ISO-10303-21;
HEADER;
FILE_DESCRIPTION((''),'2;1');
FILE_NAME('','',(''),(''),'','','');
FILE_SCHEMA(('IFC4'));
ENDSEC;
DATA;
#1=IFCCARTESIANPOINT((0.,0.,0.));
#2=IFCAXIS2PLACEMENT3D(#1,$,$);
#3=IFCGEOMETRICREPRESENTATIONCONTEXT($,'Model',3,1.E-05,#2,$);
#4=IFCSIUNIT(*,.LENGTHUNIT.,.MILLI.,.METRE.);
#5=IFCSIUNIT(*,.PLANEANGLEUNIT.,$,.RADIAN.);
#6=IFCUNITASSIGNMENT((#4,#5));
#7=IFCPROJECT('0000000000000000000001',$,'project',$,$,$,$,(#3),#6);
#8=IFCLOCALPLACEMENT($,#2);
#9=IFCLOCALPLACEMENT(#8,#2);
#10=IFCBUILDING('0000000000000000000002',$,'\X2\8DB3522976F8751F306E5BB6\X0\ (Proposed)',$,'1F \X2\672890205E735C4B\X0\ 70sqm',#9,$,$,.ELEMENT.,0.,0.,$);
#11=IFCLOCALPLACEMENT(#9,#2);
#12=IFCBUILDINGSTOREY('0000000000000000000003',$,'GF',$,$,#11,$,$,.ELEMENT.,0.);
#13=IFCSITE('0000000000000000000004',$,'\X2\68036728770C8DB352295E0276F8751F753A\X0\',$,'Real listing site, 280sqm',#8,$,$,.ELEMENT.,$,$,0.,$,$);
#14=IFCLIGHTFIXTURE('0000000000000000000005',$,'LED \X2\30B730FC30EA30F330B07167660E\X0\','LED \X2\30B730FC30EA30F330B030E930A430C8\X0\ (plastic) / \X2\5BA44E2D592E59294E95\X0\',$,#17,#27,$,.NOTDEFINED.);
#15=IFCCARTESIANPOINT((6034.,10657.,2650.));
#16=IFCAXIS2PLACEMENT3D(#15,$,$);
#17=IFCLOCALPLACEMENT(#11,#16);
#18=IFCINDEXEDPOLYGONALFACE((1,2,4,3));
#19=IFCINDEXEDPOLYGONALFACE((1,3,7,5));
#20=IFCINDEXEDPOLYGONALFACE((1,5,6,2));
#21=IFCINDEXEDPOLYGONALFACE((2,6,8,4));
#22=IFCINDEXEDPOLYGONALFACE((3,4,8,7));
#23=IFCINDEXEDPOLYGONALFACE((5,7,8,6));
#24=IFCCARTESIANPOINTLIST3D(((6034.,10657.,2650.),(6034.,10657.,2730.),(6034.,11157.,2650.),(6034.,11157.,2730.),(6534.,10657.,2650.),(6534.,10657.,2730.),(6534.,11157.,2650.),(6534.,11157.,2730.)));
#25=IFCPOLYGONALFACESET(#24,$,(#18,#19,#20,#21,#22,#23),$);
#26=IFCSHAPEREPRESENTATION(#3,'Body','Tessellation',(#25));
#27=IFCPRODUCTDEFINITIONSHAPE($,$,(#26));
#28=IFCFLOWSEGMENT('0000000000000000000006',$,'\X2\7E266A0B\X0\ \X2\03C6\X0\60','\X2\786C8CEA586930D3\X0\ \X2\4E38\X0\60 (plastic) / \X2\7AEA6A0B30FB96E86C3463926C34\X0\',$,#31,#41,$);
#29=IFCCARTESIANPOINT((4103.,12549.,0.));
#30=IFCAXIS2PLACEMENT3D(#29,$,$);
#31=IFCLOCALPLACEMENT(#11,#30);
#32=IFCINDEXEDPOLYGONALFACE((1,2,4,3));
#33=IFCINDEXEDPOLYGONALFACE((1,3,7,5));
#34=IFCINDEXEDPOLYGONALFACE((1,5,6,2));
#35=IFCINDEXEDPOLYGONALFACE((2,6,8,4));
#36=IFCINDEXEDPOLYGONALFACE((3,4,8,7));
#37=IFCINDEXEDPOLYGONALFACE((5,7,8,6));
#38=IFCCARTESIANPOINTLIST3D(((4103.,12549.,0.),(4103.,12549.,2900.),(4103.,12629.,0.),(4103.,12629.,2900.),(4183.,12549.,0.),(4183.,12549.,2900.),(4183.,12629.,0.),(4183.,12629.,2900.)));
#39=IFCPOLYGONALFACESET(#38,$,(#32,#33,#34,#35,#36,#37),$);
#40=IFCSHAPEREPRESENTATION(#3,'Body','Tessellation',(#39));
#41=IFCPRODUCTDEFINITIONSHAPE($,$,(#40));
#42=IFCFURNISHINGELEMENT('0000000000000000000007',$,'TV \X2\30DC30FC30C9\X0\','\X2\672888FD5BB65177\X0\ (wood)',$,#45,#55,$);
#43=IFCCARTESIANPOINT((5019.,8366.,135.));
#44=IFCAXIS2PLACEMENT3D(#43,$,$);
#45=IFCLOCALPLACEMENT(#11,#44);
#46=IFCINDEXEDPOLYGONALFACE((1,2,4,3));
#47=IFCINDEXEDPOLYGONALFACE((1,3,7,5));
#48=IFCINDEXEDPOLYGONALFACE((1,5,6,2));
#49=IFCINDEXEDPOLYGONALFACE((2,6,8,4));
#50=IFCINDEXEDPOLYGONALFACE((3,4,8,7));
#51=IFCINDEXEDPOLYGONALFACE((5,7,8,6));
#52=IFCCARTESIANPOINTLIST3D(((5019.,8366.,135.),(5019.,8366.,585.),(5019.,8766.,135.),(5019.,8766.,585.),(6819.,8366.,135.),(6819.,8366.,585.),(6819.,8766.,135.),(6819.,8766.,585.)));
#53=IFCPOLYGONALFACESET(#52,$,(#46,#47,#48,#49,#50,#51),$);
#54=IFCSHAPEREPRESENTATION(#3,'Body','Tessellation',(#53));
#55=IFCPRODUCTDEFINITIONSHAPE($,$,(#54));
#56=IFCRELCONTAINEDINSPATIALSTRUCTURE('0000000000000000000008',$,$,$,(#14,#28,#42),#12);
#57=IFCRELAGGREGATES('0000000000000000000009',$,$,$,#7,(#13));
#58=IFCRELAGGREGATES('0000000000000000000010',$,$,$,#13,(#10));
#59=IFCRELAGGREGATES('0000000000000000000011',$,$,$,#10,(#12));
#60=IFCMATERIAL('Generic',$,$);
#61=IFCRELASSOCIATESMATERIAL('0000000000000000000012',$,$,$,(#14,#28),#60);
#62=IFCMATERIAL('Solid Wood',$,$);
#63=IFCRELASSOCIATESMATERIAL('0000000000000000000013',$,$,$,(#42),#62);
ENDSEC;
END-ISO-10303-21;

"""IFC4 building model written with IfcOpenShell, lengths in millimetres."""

from ifc_helpers import new_model, si_unit, frame, frame_2d, origin, place, context, project, spatial, rectangle, extrude, material, element, save


model = new_model("IFC4")

# Units and contexts
model_context = context("Model", 3, precision=1e-05, world=origin())
ifc_project = project(units=[si_unit("LENGTHUNIT", "METRE", prefix="MILLI"), si_unit("PLANEANGLEUNIT", "RADIAN")], contexts=[model_context])

# Site, building, storey
site_placement = place(None, origin())
site = spatial("IfcSite", under=ifc_project, at=site_placement, Name="栃木県足利市相生町", ObjectType="Real listing site, 280sqm", CompositionType="ELEMENT", RefElevation=0.0)
building_placement = place(site_placement, origin())
building = spatial("IfcBuilding", under=site, at=building_placement, Name="足利相生の家 (Proposed)", ObjectType="1F 木造平屋 70sqm", CompositionType="ELEMENT", ElevationOfRefHeight=0.0, ElevationOfTerrain=0.0)
storey_placement = place(building_placement, origin())
storey = spatial("IfcBuildingStorey", under=building, at=storey_placement, Name="GF", CompositionType="ELEMENT", Elevation=0.0)

# Shared definitions
ifc_material_1 = material(Name="Solid Wood")

# Shared definitions
ifc_material_2 = material(Name="Generic")

# Light fixture
light_fixture_placement = place(storey_placement, frame((6034.0, 10657.0, 2650.0)))
element("IfcLightFixture", 1, at=light_fixture_placement, inside=storey, material=ifc_material_2, Name="LED シーリング照明", Description="LED シーリングライト (plastic) / 室中央天井", PredefinedType="NOTDEFINED", context=model_context, shape_type="SweptSolid", body=[
    extrude(rectangle(XDim=500.0, YDim=500.0, at=frame_2d((250.0, 250.0))), frame((6034.0, 10657.0, 2650.0)), (0.0, 0.0, 1.0), 80.0),
])

# Flow segment
flow_segment_1_placement = place(storey_placement, frame((4103.0, 12549.0, 0.0)))
element("IfcFlowSegment", 2, at=flow_segment_1_placement, inside=storey, material=ifc_material_2, Name="縦樋 φ60", Description="硬質塩ビ 丸60 (plastic) / 竪樋・雨水排水", context=model_context, shape_type="SweptSolid", body=[
    extrude(rectangle(XDim=80.0, YDim=80.0, at=frame_2d((40.0, 40.0))), frame((4103.0, 12549.0, 0.0)), (0.0, 0.0, 1.0), 2900.0),
])

# Furnishing element
furnishing_placement = place(storey_placement, frame((5019.0, 8366.0, 135.0)))
element("IfcFurnishingElement", 3, at=furnishing_placement, inside=storey, material=ifc_material_1, Name="TV ボード", Description="木製家具 (wood)", context=model_context, shape_type="SweptSolid", body=[
    extrude(rectangle(XDim=1800.0, YDim=400.0, at=frame_2d((900.0, 200.0))), frame((5019.0, 8366.0, 135.0)), (0.0, 0.0, 1.0), 450.0),
])

save(model, "model.ifc")
